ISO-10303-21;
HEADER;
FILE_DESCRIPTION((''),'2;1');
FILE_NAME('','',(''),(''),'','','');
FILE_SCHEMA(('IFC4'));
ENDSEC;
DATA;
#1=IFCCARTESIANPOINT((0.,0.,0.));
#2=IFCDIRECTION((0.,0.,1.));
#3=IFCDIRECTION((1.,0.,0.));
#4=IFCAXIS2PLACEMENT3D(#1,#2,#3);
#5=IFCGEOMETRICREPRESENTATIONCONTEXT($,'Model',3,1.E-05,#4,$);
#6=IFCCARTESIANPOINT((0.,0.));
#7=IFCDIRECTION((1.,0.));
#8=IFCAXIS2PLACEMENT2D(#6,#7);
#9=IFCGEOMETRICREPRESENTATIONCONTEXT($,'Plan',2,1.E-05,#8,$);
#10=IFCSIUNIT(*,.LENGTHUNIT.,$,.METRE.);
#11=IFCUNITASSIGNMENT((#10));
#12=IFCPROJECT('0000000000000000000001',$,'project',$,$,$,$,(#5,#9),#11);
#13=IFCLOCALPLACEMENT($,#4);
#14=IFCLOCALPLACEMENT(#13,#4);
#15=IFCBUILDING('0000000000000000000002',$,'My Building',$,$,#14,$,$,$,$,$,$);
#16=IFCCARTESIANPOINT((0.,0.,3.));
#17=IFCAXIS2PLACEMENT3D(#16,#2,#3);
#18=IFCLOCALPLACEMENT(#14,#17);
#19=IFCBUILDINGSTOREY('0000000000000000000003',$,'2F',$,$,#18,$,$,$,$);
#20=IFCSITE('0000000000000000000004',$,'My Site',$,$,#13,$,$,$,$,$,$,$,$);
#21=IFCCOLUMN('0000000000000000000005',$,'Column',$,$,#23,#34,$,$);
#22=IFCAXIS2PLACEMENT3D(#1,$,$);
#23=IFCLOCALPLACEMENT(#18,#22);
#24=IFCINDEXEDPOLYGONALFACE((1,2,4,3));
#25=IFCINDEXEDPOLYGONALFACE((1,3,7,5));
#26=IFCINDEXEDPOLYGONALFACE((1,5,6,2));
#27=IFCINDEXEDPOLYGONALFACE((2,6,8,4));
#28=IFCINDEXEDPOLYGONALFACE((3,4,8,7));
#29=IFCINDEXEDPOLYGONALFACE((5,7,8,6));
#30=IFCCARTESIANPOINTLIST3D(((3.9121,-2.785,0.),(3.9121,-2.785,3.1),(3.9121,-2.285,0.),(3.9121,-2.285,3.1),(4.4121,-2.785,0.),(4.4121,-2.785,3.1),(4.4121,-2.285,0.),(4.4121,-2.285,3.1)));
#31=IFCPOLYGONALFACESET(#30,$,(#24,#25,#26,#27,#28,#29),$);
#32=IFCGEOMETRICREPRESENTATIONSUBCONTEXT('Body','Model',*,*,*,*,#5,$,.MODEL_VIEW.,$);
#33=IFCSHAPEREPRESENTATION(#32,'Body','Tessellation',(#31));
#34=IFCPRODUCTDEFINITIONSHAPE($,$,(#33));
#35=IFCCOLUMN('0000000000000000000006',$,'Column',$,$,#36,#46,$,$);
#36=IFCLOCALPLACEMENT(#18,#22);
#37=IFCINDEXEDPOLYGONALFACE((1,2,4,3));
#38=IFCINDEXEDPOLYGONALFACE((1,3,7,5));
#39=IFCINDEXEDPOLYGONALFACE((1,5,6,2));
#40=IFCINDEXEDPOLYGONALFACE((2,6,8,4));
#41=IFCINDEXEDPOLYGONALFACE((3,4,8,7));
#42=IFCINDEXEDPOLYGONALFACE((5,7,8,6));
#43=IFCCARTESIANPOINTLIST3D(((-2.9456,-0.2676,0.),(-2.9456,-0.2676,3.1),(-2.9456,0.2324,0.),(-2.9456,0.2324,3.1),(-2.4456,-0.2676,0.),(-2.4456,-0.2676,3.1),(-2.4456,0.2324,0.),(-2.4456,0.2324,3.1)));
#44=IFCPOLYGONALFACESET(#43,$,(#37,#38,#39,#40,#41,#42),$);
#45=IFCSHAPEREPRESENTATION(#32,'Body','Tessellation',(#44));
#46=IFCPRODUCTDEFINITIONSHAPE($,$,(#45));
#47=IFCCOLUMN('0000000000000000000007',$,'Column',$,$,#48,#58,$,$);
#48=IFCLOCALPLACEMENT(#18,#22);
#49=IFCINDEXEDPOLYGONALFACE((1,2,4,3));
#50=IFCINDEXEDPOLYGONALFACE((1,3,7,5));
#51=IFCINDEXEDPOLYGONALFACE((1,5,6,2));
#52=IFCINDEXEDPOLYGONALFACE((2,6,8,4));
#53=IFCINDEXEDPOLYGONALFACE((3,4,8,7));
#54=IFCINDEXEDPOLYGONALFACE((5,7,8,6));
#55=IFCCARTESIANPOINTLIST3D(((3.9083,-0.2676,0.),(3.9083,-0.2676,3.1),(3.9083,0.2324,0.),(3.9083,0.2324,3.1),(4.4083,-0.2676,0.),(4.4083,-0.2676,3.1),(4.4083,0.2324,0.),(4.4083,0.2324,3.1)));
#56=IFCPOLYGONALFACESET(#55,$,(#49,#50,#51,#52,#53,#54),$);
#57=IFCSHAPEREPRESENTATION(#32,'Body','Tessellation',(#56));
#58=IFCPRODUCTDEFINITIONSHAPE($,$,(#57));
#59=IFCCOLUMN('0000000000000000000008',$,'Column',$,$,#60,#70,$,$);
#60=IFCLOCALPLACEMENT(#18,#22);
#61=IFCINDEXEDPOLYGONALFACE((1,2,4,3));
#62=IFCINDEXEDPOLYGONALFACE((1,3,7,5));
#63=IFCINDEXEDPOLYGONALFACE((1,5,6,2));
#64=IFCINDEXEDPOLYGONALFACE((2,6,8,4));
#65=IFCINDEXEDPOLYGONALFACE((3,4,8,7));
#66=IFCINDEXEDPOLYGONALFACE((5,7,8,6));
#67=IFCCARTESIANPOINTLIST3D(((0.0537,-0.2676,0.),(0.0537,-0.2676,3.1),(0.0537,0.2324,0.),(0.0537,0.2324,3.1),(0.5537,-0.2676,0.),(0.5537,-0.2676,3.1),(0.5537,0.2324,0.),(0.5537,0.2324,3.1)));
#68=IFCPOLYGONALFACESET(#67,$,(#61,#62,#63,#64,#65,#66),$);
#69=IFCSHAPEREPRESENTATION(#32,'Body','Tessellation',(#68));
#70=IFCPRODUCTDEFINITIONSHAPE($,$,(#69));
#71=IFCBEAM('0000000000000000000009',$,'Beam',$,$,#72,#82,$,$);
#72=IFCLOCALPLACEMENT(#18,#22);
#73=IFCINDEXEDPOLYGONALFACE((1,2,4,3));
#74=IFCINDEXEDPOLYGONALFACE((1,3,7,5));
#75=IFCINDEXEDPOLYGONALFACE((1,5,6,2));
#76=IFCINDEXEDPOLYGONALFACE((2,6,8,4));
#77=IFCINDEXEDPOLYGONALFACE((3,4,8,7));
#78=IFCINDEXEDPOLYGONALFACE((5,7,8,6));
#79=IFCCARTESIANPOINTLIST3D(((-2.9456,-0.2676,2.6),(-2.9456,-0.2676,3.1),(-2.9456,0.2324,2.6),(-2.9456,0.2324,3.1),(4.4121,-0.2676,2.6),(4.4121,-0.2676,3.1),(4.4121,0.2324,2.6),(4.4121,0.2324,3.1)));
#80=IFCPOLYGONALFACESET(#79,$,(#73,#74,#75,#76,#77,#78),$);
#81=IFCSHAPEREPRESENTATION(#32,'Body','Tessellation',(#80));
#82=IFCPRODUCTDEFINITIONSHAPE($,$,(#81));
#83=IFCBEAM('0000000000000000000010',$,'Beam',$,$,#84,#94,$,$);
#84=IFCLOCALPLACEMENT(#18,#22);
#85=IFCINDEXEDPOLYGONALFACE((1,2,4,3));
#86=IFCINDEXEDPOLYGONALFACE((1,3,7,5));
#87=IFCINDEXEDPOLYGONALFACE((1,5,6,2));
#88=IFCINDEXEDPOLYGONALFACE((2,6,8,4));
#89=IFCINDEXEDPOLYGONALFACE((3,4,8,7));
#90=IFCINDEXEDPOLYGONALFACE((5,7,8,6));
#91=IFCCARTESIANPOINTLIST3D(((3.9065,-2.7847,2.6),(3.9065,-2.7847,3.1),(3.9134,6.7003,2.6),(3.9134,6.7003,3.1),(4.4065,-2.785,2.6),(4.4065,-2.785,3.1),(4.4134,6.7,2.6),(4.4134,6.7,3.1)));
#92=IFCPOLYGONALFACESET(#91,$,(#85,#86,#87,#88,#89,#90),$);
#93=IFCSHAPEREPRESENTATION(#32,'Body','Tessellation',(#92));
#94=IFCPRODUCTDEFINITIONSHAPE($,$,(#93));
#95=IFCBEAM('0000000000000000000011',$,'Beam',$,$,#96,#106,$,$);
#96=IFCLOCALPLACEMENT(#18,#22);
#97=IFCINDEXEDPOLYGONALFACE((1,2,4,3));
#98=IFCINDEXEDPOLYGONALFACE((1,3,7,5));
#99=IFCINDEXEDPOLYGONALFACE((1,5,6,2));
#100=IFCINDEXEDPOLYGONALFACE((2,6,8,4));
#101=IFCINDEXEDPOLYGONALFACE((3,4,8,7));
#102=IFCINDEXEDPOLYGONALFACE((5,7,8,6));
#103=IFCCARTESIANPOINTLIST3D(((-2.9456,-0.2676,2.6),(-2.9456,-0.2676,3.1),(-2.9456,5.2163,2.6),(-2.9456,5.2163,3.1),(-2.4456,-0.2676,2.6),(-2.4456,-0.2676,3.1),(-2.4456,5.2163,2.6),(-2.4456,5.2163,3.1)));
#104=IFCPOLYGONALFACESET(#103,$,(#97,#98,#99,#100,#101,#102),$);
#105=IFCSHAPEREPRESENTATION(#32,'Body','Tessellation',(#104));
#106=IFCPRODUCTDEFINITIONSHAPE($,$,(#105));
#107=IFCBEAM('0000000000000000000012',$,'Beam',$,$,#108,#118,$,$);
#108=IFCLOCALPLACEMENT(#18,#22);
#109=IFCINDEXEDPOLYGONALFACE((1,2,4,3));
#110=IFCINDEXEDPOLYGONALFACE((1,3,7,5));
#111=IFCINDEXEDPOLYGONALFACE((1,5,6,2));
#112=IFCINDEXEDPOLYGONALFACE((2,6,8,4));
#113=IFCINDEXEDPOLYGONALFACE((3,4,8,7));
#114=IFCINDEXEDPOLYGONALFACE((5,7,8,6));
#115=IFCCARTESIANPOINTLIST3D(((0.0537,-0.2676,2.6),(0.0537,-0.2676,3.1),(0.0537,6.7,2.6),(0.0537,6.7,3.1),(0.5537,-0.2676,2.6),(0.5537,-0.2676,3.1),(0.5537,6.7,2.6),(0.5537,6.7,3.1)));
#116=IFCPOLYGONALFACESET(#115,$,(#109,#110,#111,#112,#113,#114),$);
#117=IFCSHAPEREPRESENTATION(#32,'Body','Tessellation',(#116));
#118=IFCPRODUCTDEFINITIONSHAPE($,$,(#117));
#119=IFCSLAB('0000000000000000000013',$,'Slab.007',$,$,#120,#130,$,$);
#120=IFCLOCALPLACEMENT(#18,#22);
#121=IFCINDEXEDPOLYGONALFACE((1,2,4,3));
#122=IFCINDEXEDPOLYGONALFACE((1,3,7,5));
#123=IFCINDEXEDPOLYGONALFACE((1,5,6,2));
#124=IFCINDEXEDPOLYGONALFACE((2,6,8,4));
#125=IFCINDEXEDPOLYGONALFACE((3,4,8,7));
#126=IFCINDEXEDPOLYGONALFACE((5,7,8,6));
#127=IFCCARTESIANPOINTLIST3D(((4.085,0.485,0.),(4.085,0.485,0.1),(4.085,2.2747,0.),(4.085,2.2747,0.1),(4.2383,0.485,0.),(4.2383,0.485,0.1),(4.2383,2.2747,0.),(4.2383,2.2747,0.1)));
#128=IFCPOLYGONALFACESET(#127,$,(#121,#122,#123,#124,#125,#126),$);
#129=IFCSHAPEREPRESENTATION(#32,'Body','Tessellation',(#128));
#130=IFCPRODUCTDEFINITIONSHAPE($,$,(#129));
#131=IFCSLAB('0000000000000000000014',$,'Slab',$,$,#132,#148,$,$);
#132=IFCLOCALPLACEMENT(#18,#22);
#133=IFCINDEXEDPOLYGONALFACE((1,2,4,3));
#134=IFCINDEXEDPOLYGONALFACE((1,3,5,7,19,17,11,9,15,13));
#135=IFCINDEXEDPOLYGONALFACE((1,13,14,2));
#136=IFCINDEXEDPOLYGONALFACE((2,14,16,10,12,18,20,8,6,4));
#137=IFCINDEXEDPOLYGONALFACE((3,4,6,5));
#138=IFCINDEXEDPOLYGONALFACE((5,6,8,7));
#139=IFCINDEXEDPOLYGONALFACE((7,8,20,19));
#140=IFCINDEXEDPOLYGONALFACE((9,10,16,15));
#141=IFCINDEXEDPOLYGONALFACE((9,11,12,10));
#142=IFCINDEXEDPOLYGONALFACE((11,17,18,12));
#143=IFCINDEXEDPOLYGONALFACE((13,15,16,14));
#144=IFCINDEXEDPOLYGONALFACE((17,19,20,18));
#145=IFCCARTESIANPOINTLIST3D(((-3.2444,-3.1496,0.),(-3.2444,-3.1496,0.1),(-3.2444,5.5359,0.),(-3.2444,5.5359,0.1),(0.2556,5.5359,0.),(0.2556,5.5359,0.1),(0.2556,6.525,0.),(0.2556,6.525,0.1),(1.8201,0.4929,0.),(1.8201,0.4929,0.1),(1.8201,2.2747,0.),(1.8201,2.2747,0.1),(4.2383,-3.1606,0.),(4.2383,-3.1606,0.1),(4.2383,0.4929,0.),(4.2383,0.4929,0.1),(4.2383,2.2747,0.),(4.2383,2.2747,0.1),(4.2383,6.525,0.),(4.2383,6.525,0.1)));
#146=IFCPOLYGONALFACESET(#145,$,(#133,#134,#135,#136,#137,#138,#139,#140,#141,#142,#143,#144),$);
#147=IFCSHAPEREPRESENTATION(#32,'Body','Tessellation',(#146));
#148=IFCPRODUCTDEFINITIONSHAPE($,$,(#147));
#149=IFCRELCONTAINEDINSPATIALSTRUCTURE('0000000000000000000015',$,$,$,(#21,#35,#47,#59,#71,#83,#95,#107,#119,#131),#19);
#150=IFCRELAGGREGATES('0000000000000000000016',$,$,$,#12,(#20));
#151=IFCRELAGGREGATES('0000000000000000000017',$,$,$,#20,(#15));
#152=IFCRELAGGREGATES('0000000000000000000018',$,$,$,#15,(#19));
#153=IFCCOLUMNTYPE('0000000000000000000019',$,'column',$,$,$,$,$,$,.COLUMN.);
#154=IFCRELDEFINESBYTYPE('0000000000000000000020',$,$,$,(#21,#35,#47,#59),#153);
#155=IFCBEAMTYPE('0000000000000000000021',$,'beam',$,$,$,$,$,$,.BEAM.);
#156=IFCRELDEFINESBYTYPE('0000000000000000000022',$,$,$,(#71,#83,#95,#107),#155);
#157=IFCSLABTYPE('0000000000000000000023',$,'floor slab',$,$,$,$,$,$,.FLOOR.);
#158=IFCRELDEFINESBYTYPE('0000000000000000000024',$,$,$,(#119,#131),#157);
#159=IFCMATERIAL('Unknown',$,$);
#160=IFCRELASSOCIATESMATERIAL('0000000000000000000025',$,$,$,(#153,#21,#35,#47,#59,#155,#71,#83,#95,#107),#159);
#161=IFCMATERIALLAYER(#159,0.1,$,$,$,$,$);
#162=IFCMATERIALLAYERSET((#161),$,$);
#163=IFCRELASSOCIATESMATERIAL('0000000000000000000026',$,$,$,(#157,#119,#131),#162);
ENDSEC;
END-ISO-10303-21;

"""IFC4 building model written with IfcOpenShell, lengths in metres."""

from ifc_helpers import new_model, si_unit, frame, origin_with_axes, origin_2d_with_axis, place, context, subcontext, project, spatial, indexed_curve, rectangle, outline, extrude, material, layer, layer_set, layer_usage, material_profile, profile_set, profile_usage, type_object, element, save


model = new_model("IFC4")

# Units and contexts
model_context = context("Model", 3, precision=1e-05, world=origin_with_axes())
plan_context = context("Plan", 2, precision=1e-05, world=origin_2d_with_axis())
body_context_1 = subcontext(model_context, "Body", "Model", "MODEL_VIEW")
ifc_project = project(units=[si_unit("LENGTHUNIT", "METRE")], contexts=[model_context, plan_context])

# Site, building, storey
site_placement = place(None, origin_with_axes())
site = spatial("IfcSite", under=ifc_project, at=site_placement, Name="My Site")
building_placement = place(site_placement, origin_with_axes())
building = spatial("IfcBuilding", under=site, at=building_placement, Name="My Building")
storey_placement = place(building_placement, frame((0.0, 0.0, 3.0), z_axis=(0.0, 0.0, 1.0), x_axis=(1.0, 0.0, 0.0)))
storey = spatial("IfcBuildingStorey", under=building, at=storey_placement, Name="2F")

# Columns
ifc_material = material(Name="Unknown")
ifc_material_profile_1 = material_profile(ifc_material, rectangle(XDim=0.5, YDim=0.5))
ifc_profile_set_1 = profile_set([ifc_material_profile_1])
ifc_profile_usage_1 = profile_usage(ifc_profile_set_1, cardinal=5)
column_type = type_object("IfcColumnType", Name="column", PredefinedType="COLUMN", material=ifc_profile_set_1)
column_1_placement = place(storey_placement, frame((4.1621, -2.535, 0.0), z_axis=(0.0, 0.0, 1.0), x_axis=(1.0, 0.0, 0.0)))
element("IfcColumn", 1, at=column_1_placement, inside=storey, type_object=column_type, material=ifc_profile_usage_1, Name="Column", context=body_context_1, shape_type="SweptSolid", body=[
    extrude(rectangle(XDim=0.5, YDim=0.5), origin_with_axes(), (0.0, 0.0, 1.0), 3.1),
])
ifc_profile_usage_2 = profile_usage(ifc_profile_set_1, cardinal=5)
column_2_placement = place(storey_placement, frame((-2.6956, -0.0176, 0.0), z_axis=(0.0, 0.0, 1.0), x_axis=(1.0, 0.0, 0.0)))
element("IfcColumn", 2, at=column_2_placement, inside=storey, type_object=column_type, material=ifc_profile_usage_2, Name="Column", context=body_context_1, shape_type="SweptSolid", body=[
    extrude(rectangle(XDim=0.5, YDim=0.5), origin_with_axes(), (0.0, 0.0, 1.0), 3.1),
])
ifc_profile_usage_3 = profile_usage(ifc_profile_set_1, cardinal=5)
column_3_placement = place(storey_placement, frame((4.1583, -0.0176, 0.0), z_axis=(0.0, 0.0, 1.0), x_axis=(1.0, 0.0, 0.0)))
element("IfcColumn", 3, at=column_3_placement, inside=storey, type_object=column_type, material=ifc_profile_usage_3, Name="Column", context=body_context_1, shape_type="SweptSolid", body=[
    extrude(rectangle(XDim=0.5, YDim=0.5), origin_with_axes(), (0.0, 0.0, 1.0), 3.1),
])
ifc_profile_usage_4 = profile_usage(ifc_profile_set_1, cardinal=5)
column_4_placement = place(storey_placement, frame((0.3037, -0.0176, 0.0), z_axis=(0.0, 0.0, 1.0), x_axis=(1.0, 0.0, 0.0)))
element("IfcColumn", 4, at=column_4_placement, inside=storey, type_object=column_type, material=ifc_profile_usage_4, Name="Column", context=body_context_1, shape_type="SweptSolid", body=[
    extrude(rectangle(XDim=0.5, YDim=0.5), origin_with_axes(), (0.0, 0.0, 1.0), 3.1),
])

# Beams
ifc_material_profile_2 = material_profile(ifc_material, rectangle(XDim=0.5, YDim=0.5))
ifc_profile_set_2 = profile_set([ifc_material_profile_2])
ifc_profile_usage_5 = profile_usage(ifc_profile_set_2, cardinal=9)
beam_type = type_object("IfcBeamType", Name="beam", PredefinedType="BEAM", material=ifc_profile_set_2)
beam_1_placement = place(storey_placement, frame((-2.9456, -0.2676, 3.1), z_axis=(1.0, 0.0, 0.0), x_axis=(0.0, 1.0, 0.0)))
element("IfcBeam", 5, at=beam_1_placement, inside=storey, type_object=beam_type, material=ifc_profile_usage_5, Name="Beam", context=body_context_1, shape_type="SweptSolid", body=[
    extrude(rectangle(XDim=0.5, YDim=0.5), frame((0.25, -0.25, 0.0), z_axis=(0.0, 0.0, 1.0), x_axis=(1.0, 0.0, 0.0)), (0.0, 0.0, 1.0), 7.3577),
])
ifc_profile_usage_6 = profile_usage(ifc_profile_set_2, cardinal=9)
beam_2_placement = place(storey_placement, frame((4.4065, -2.785, 3.1), z_axis=(0.000725, 1.0, 0.0), x_axis=(-1.0, 0.000725, 0.0)))
element("IfcBeam", 6, at=beam_2_placement, inside=storey, type_object=beam_type, material=ifc_profile_usage_6, Name="Beam", context=body_context_1, shape_type="SweptSolid", body=[
    extrude(rectangle(XDim=0.5, YDim=0.5), frame((0.25, -0.25, 0.0), z_axis=(0.0, 0.0, 1.0), x_axis=(1.0, 0.0, 0.0)), (0.0, 0.0, 1.0), 9.485),
])
ifc_profile_usage_7 = profile_usage(ifc_profile_set_2, cardinal=9)
beam_3_placement = place(storey_placement, frame((-2.4456, -0.2676, 3.1), z_axis=(0.0, 1.0, 0.0), x_axis=(-1.0, 0.0, 0.0)))
element("IfcBeam", 7, at=beam_3_placement, inside=storey, type_object=beam_type, material=ifc_profile_usage_7, Name="Beam", context=body_context_1, shape_type="SweptSolid", body=[
    extrude(rectangle(XDim=0.5, YDim=0.5), frame((0.25, -0.25, 0.0), z_axis=(0.0, 0.0, 1.0), x_axis=(1.0, 0.0, 0.0)), (0.0, 0.0, 1.0), 5.4839),
])
ifc_profile_usage_8 = profile_usage(ifc_profile_set_2, cardinal=9)
beam_4_placement = place(storey_placement, frame((0.5537, -0.2676, 3.1), z_axis=(0.0, 1.0, 0.0), x_axis=(-1.0, 0.0, 0.0)))
element("IfcBeam", 8, at=beam_4_placement, inside=storey, type_object=beam_type, material=ifc_profile_usage_8, Name="Beam", context=body_context_1, shape_type="SweptSolid", body=[
    extrude(rectangle(XDim=0.5, YDim=0.5), frame((0.25, -0.25, 0.0), z_axis=(0.0, 0.0, 1.0), x_axis=(1.0, 0.0, 0.0)), (0.0, 0.0, 1.0), 6.9675),
])

# Slabs
ifc_layer_1 = layer(ifc_material, 0.1)
ifc_layer_set_1 = layer_set([ifc_layer_1])
ifc_layer_usage_1 = layer_usage(ifc_layer_set_1, "AXIS3", "POSITIVE", -0.1)
slab_type = type_object("IfcSlabType", Name="floor slab", PredefinedType="FLOOR", material=ifc_layer_set_1)
slab_1_placement = place(storey_placement, frame((4.2383, 2.2747, 0.1), z_axis=(0.0, 0.0, 1.0), x_axis=(1.0, 0.0, 0.0)))
element("IfcSlab", 9, at=slab_1_placement, inside=storey, type_object=slab_type, material=ifc_layer_usage_1, Name="Slab.007", context=body_context_1, shape_type="SweptSolid", body=[
    extrude(outline(indexed_curve([(0.0, 0.0), (0.0, -1.7897), (-0.1533, -1.7897), (-0.1533, 0.0), (0.0, 0.0)])), frame((0.0, 0.0, -0.1), z_axis=(0.0, 0.0, 1.0), x_axis=(1.0, 0.0, 0.0)), (0.0, 0.0, 1.0), 0.1),
])
ifc_layer_usage_2 = layer_usage(ifc_layer_set_1, "AXIS3", "POSITIVE", -0.1)
slab_2_placement = place(storey_placement, frame((4.2383, -3.1606, 0.1), z_axis=(0.0, 0.0, 1.0), x_axis=(1.0, 0.0, 0.0)))
element("IfcSlab", 10, at=slab_2_placement, inside=storey, type_object=slab_type, material=ifc_layer_usage_2, Name="Slab", context=body_context_1, shape_type="SweptSolid", body=[
    extrude(outline(indexed_curve([(0.0, 0.0), (0.0, 3.6536), (-2.4183, 3.6536), (-2.4183, 5.4353), (0.0, 5.4353), (0.0, 9.6856), (-3.9827, 9.6856), (-3.9827, 8.6965), (-7.4827, 8.6965), (-7.4827, 0.011), (0.0, 0.0)])), frame((0.0, 0.0, -0.1), z_axis=(0.0, 0.0, 1.0), x_axis=(1.0, 0.0, 0.0)), (0.0, 0.0, 1.0), 0.1),
])

save(model, "model.ifc")
